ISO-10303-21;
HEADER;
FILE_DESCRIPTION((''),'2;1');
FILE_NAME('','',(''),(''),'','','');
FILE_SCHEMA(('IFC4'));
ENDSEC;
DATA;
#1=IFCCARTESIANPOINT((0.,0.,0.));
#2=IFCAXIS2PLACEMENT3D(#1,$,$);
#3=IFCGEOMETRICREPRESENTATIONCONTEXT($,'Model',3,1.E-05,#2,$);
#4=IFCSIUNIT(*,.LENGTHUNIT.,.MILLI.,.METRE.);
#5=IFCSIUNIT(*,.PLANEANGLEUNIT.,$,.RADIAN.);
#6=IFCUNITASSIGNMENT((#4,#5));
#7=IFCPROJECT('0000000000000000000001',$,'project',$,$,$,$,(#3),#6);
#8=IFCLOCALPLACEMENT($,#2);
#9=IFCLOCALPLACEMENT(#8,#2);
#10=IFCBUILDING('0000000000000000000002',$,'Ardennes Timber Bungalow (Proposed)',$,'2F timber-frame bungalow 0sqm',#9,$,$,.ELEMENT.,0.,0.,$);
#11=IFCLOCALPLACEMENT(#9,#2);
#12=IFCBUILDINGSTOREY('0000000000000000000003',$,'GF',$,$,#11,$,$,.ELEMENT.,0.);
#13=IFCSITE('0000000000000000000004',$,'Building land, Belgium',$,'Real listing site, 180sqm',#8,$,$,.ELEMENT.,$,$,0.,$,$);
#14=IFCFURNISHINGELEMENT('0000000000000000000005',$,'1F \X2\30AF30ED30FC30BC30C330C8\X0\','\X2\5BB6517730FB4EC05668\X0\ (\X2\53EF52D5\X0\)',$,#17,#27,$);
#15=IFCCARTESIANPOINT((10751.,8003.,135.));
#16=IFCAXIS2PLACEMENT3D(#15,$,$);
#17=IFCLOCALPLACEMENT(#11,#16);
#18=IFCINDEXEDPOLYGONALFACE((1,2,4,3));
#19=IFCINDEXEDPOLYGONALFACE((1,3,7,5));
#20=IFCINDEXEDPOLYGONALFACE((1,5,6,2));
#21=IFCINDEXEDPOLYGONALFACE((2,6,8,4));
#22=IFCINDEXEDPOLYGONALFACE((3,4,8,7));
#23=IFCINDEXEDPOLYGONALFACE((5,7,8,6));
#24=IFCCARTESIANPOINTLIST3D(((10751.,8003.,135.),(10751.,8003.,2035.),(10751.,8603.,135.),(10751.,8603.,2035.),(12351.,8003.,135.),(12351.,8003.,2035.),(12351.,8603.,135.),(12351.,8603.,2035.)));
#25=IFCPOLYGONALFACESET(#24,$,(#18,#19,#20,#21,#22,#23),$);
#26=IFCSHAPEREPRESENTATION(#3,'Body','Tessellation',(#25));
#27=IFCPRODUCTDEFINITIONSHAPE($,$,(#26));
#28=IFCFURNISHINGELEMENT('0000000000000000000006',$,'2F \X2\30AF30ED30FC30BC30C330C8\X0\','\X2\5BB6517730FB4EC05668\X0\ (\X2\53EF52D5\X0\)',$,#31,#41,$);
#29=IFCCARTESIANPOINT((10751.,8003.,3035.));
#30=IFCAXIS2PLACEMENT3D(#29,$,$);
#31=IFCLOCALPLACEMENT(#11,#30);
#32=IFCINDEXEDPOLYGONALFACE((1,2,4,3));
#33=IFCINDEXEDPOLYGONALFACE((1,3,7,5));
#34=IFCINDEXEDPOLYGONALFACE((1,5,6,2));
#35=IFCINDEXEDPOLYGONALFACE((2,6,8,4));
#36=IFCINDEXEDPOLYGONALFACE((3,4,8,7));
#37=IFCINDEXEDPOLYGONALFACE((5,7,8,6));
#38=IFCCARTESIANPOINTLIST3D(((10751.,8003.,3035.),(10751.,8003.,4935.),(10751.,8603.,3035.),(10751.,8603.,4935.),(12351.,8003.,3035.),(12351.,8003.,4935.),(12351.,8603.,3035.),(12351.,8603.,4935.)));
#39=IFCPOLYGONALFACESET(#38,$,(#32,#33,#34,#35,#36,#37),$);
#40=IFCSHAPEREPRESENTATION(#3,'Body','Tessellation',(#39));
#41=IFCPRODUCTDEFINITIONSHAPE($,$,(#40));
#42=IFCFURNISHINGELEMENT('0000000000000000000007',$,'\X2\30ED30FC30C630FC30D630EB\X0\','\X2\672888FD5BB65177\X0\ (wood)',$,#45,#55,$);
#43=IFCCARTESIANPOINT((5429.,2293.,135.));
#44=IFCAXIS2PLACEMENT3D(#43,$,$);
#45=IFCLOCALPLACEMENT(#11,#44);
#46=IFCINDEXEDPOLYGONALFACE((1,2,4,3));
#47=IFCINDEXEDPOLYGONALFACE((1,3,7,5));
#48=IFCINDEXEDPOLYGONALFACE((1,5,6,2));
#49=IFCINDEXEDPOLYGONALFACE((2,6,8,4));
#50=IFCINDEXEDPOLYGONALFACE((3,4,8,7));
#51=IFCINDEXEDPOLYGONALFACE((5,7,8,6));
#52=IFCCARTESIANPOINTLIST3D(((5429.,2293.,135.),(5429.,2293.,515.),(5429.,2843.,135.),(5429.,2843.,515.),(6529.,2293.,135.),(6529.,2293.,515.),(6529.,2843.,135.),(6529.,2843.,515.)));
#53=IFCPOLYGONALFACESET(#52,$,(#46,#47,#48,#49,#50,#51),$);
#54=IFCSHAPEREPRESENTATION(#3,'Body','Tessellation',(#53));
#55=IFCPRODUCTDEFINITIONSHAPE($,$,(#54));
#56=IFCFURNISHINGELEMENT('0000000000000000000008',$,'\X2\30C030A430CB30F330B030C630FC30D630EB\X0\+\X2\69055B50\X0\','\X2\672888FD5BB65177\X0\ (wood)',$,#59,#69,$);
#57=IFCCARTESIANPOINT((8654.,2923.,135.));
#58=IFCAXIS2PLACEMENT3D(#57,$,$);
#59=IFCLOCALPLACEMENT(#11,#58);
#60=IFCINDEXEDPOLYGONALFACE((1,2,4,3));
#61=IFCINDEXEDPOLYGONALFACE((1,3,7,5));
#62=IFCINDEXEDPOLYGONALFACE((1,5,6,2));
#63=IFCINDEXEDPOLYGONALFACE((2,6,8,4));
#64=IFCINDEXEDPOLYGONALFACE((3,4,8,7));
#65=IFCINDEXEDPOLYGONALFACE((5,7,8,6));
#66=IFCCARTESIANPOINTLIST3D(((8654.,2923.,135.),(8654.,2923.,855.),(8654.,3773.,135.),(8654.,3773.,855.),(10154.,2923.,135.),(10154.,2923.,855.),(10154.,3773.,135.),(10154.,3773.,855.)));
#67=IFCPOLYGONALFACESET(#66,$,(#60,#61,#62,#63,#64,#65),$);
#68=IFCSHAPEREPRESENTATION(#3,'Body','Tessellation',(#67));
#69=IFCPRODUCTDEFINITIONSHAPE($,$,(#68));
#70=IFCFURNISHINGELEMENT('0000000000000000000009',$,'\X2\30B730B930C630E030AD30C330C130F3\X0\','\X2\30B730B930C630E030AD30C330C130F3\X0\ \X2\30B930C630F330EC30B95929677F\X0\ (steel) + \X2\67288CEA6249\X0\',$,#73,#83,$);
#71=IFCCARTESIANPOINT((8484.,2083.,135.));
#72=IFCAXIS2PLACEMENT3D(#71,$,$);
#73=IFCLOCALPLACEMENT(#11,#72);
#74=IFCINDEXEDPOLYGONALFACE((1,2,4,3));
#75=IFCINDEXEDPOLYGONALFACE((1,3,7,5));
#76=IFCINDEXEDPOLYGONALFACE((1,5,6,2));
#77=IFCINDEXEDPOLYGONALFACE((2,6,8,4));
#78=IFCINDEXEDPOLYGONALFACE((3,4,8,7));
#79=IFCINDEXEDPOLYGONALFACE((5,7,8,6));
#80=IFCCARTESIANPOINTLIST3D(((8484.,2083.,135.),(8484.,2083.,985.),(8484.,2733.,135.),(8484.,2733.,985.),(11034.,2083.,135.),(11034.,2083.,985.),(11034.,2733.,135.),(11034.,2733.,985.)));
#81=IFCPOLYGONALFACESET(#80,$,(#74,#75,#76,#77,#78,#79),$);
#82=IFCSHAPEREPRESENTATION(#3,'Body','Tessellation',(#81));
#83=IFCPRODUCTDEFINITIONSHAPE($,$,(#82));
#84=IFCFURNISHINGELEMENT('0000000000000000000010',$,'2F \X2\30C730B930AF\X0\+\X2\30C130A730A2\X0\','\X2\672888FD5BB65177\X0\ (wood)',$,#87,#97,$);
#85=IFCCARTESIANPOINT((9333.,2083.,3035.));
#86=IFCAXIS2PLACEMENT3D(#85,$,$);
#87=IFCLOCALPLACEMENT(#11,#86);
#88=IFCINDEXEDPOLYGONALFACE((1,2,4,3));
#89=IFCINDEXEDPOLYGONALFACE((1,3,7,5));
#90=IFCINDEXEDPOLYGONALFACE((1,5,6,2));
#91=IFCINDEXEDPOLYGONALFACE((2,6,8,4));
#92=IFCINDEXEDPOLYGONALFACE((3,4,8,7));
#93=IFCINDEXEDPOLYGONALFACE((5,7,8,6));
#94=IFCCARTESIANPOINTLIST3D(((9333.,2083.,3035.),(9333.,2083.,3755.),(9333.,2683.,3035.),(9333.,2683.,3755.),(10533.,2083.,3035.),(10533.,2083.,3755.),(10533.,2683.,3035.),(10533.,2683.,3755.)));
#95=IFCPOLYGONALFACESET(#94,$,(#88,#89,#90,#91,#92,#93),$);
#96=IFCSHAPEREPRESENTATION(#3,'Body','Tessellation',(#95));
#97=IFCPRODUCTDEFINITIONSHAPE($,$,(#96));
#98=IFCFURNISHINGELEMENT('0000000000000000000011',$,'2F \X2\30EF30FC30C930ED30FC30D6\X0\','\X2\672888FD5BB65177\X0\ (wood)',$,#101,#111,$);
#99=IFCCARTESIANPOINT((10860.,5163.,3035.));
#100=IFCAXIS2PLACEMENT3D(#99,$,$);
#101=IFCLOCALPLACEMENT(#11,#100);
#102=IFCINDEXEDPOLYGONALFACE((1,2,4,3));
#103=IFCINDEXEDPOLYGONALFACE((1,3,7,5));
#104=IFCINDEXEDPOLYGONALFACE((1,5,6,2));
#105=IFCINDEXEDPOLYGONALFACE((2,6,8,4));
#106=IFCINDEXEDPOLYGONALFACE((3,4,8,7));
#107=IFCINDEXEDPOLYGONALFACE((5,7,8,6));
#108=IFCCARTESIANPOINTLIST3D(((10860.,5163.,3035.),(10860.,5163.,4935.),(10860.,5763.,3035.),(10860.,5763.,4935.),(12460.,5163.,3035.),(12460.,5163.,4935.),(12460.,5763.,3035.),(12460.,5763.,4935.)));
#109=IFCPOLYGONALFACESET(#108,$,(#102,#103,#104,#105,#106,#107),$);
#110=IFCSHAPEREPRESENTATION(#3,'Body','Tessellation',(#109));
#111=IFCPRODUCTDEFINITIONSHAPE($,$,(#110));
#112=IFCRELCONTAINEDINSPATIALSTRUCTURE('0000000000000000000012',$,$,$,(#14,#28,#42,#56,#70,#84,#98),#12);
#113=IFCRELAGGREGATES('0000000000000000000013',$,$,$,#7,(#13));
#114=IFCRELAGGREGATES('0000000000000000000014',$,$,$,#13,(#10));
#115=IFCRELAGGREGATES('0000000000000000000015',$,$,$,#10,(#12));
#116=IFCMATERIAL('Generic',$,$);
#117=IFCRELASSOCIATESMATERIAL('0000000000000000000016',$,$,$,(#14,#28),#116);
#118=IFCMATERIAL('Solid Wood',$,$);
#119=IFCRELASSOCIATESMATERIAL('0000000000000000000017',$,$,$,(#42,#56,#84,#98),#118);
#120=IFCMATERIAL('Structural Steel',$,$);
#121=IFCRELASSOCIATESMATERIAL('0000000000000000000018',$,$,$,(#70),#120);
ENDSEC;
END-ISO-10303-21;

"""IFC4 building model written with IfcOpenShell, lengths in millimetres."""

from ifc_helpers import new_model, si_unit, frame, frame_2d, origin, place, context, project, spatial, rectangle, extrude, material, element, save


model = new_model("IFC4")

# Units and contexts
model_context = context("Model", 3, precision=1e-05, world=origin())
ifc_project = project(units=[si_unit("LENGTHUNIT", "METRE", prefix="MILLI"), si_unit("PLANEANGLEUNIT", "RADIAN")], contexts=[model_context])

# Site, building, storey
site_placement = place(None, origin())
site = spatial("IfcSite", under=ifc_project, at=site_placement, Name="Building land, Belgium", ObjectType="Real listing site, 180sqm", CompositionType="ELEMENT", RefElevation=0.0)
building_placement = place(site_placement, origin())
building = spatial("IfcBuilding", under=site, at=building_placement, Name="Ardennes Timber Bungalow (Proposed)", ObjectType="2F timber-frame bungalow 0sqm", CompositionType="ELEMENT", ElevationOfRefHeight=0.0, ElevationOfTerrain=0.0)
storey_placement = place(building_placement, origin())
storey = spatial("IfcBuildingStorey", under=building, at=storey_placement, Name="GF", CompositionType="ELEMENT", Elevation=0.0)

# Shared definitions
ifc_material_1 = material(Name="Solid Wood")

# Shared definitions
ifc_material_2 = material(Name="Generic")

# Furnishing elements
furnishing_1_placement = place(storey_placement, frame((10751.0, 8003.0, 135.0)))
element("IfcFurnishingElement", 1, at=furnishing_1_placement, inside=storey, material=ifc_material_2, Name="1F クローゼット", Description="家具・什器 (可動)", context=model_context, shape_type="SweptSolid", body=[
    extrude(rectangle(XDim=1600.0, YDim=600.0, at=frame_2d((800.0, 300.0))), frame((10751.0, 8003.0, 135.0)), (0.0, 0.0, 1.0), 1900.0),
])
furnishing_2_placement = place(storey_placement, frame((10751.0, 8003.0, 3035.0)))
element("IfcFurnishingElement", 2, at=furnishing_2_placement, inside=storey, material=ifc_material_2, Name="2F クローゼット", Description="家具・什器 (可動)", context=model_context, shape_type="SweptSolid", body=[
    extrude(rectangle(XDim=1600.0, YDim=600.0, at=frame_2d((800.0, 300.0))), frame((10751.0, 8003.0, 3035.0)), (0.0, 0.0, 1.0), 1900.0),
])
furnishing_3_placement = place(storey_placement, frame((5429.0, 2293.0, 135.0)))
element("IfcFurnishingElement", 3, at=furnishing_3_placement, inside=storey, material=ifc_material_1, Name="ローテーブル", Description="木製家具 (wood)", context=model_context, shape_type="SweptSolid", body=[
    extrude(rectangle(XDim=1100.0, YDim=550.0, at=frame_2d((550.0, 275.0))), frame((5429.0, 2293.0, 135.0)), (0.0, 0.0, 1.0), 380.0),
])
furnishing_4_placement = place(storey_placement, frame((8654.0, 2923.0, 135.0)))
element("IfcFurnishingElement", 4, at=furnishing_4_placement, inside=storey, material=ifc_material_1, Name="ダイニングテーブル+椅子", Description="木製家具 (wood)", context=model_context, shape_type="SweptSolid", body=[
    extrude(rectangle(XDim=1500.0, YDim=850.0, at=frame_2d((750.0, 425.0))), frame((8654.0, 2923.0, 135.0)), (0.0, 0.0, 1.0), 720.0),
])
ifc_material_3 = material(Name="Structural Steel")
furnishing_5_placement = place(storey_placement, frame((8484.0, 2083.0, 135.0)))
element("IfcFurnishingElement", 5, at=furnishing_5_placement, inside=storey, material=ifc_material_3, Name="システムキッチン", Description="システムキッチン ステンレス天板 (steel) + 木質扉", context=model_context, shape_type="SweptSolid", body=[
    extrude(rectangle(XDim=2550.0, YDim=650.0, at=frame_2d((1275.0, 325.0))), frame((8484.0, 2083.0, 135.0)), (0.0, 0.0, 1.0), 850.0),
])
furnishing_6_placement = place(storey_placement, frame((9333.0, 2083.0, 3035.0)))
element("IfcFurnishingElement", 6, at=furnishing_6_placement, inside=storey, material=ifc_material_1, Name="2F デスク+チェア", Description="木製家具 (wood)", context=model_context, shape_type="SweptSolid", body=[
    extrude(rectangle(XDim=1200.0, YDim=600.0, at=frame_2d((600.0, 300.0))), frame((9333.0, 2083.0, 3035.0)), (0.0, 0.0, 1.0), 720.0),
])
furnishing_7_placement = place(storey_placement, frame((10860.0, 5163.0, 3035.0)))
element("IfcFurnishingElement", 7, at=furnishing_7_placement, inside=storey, material=ifc_material_1, Name="2F ワードローブ", Description="木製家具 (wood)", context=model_context, shape_type="SweptSolid", body=[
    extrude(rectangle(XDim=1600.0, YDim=600.0, at=frame_2d((800.0, 300.0))), frame((10860.0, 5163.0, 3035.0)), (0.0, 0.0, 1.0), 1900.0),
])

save(model, "model.ifc")
